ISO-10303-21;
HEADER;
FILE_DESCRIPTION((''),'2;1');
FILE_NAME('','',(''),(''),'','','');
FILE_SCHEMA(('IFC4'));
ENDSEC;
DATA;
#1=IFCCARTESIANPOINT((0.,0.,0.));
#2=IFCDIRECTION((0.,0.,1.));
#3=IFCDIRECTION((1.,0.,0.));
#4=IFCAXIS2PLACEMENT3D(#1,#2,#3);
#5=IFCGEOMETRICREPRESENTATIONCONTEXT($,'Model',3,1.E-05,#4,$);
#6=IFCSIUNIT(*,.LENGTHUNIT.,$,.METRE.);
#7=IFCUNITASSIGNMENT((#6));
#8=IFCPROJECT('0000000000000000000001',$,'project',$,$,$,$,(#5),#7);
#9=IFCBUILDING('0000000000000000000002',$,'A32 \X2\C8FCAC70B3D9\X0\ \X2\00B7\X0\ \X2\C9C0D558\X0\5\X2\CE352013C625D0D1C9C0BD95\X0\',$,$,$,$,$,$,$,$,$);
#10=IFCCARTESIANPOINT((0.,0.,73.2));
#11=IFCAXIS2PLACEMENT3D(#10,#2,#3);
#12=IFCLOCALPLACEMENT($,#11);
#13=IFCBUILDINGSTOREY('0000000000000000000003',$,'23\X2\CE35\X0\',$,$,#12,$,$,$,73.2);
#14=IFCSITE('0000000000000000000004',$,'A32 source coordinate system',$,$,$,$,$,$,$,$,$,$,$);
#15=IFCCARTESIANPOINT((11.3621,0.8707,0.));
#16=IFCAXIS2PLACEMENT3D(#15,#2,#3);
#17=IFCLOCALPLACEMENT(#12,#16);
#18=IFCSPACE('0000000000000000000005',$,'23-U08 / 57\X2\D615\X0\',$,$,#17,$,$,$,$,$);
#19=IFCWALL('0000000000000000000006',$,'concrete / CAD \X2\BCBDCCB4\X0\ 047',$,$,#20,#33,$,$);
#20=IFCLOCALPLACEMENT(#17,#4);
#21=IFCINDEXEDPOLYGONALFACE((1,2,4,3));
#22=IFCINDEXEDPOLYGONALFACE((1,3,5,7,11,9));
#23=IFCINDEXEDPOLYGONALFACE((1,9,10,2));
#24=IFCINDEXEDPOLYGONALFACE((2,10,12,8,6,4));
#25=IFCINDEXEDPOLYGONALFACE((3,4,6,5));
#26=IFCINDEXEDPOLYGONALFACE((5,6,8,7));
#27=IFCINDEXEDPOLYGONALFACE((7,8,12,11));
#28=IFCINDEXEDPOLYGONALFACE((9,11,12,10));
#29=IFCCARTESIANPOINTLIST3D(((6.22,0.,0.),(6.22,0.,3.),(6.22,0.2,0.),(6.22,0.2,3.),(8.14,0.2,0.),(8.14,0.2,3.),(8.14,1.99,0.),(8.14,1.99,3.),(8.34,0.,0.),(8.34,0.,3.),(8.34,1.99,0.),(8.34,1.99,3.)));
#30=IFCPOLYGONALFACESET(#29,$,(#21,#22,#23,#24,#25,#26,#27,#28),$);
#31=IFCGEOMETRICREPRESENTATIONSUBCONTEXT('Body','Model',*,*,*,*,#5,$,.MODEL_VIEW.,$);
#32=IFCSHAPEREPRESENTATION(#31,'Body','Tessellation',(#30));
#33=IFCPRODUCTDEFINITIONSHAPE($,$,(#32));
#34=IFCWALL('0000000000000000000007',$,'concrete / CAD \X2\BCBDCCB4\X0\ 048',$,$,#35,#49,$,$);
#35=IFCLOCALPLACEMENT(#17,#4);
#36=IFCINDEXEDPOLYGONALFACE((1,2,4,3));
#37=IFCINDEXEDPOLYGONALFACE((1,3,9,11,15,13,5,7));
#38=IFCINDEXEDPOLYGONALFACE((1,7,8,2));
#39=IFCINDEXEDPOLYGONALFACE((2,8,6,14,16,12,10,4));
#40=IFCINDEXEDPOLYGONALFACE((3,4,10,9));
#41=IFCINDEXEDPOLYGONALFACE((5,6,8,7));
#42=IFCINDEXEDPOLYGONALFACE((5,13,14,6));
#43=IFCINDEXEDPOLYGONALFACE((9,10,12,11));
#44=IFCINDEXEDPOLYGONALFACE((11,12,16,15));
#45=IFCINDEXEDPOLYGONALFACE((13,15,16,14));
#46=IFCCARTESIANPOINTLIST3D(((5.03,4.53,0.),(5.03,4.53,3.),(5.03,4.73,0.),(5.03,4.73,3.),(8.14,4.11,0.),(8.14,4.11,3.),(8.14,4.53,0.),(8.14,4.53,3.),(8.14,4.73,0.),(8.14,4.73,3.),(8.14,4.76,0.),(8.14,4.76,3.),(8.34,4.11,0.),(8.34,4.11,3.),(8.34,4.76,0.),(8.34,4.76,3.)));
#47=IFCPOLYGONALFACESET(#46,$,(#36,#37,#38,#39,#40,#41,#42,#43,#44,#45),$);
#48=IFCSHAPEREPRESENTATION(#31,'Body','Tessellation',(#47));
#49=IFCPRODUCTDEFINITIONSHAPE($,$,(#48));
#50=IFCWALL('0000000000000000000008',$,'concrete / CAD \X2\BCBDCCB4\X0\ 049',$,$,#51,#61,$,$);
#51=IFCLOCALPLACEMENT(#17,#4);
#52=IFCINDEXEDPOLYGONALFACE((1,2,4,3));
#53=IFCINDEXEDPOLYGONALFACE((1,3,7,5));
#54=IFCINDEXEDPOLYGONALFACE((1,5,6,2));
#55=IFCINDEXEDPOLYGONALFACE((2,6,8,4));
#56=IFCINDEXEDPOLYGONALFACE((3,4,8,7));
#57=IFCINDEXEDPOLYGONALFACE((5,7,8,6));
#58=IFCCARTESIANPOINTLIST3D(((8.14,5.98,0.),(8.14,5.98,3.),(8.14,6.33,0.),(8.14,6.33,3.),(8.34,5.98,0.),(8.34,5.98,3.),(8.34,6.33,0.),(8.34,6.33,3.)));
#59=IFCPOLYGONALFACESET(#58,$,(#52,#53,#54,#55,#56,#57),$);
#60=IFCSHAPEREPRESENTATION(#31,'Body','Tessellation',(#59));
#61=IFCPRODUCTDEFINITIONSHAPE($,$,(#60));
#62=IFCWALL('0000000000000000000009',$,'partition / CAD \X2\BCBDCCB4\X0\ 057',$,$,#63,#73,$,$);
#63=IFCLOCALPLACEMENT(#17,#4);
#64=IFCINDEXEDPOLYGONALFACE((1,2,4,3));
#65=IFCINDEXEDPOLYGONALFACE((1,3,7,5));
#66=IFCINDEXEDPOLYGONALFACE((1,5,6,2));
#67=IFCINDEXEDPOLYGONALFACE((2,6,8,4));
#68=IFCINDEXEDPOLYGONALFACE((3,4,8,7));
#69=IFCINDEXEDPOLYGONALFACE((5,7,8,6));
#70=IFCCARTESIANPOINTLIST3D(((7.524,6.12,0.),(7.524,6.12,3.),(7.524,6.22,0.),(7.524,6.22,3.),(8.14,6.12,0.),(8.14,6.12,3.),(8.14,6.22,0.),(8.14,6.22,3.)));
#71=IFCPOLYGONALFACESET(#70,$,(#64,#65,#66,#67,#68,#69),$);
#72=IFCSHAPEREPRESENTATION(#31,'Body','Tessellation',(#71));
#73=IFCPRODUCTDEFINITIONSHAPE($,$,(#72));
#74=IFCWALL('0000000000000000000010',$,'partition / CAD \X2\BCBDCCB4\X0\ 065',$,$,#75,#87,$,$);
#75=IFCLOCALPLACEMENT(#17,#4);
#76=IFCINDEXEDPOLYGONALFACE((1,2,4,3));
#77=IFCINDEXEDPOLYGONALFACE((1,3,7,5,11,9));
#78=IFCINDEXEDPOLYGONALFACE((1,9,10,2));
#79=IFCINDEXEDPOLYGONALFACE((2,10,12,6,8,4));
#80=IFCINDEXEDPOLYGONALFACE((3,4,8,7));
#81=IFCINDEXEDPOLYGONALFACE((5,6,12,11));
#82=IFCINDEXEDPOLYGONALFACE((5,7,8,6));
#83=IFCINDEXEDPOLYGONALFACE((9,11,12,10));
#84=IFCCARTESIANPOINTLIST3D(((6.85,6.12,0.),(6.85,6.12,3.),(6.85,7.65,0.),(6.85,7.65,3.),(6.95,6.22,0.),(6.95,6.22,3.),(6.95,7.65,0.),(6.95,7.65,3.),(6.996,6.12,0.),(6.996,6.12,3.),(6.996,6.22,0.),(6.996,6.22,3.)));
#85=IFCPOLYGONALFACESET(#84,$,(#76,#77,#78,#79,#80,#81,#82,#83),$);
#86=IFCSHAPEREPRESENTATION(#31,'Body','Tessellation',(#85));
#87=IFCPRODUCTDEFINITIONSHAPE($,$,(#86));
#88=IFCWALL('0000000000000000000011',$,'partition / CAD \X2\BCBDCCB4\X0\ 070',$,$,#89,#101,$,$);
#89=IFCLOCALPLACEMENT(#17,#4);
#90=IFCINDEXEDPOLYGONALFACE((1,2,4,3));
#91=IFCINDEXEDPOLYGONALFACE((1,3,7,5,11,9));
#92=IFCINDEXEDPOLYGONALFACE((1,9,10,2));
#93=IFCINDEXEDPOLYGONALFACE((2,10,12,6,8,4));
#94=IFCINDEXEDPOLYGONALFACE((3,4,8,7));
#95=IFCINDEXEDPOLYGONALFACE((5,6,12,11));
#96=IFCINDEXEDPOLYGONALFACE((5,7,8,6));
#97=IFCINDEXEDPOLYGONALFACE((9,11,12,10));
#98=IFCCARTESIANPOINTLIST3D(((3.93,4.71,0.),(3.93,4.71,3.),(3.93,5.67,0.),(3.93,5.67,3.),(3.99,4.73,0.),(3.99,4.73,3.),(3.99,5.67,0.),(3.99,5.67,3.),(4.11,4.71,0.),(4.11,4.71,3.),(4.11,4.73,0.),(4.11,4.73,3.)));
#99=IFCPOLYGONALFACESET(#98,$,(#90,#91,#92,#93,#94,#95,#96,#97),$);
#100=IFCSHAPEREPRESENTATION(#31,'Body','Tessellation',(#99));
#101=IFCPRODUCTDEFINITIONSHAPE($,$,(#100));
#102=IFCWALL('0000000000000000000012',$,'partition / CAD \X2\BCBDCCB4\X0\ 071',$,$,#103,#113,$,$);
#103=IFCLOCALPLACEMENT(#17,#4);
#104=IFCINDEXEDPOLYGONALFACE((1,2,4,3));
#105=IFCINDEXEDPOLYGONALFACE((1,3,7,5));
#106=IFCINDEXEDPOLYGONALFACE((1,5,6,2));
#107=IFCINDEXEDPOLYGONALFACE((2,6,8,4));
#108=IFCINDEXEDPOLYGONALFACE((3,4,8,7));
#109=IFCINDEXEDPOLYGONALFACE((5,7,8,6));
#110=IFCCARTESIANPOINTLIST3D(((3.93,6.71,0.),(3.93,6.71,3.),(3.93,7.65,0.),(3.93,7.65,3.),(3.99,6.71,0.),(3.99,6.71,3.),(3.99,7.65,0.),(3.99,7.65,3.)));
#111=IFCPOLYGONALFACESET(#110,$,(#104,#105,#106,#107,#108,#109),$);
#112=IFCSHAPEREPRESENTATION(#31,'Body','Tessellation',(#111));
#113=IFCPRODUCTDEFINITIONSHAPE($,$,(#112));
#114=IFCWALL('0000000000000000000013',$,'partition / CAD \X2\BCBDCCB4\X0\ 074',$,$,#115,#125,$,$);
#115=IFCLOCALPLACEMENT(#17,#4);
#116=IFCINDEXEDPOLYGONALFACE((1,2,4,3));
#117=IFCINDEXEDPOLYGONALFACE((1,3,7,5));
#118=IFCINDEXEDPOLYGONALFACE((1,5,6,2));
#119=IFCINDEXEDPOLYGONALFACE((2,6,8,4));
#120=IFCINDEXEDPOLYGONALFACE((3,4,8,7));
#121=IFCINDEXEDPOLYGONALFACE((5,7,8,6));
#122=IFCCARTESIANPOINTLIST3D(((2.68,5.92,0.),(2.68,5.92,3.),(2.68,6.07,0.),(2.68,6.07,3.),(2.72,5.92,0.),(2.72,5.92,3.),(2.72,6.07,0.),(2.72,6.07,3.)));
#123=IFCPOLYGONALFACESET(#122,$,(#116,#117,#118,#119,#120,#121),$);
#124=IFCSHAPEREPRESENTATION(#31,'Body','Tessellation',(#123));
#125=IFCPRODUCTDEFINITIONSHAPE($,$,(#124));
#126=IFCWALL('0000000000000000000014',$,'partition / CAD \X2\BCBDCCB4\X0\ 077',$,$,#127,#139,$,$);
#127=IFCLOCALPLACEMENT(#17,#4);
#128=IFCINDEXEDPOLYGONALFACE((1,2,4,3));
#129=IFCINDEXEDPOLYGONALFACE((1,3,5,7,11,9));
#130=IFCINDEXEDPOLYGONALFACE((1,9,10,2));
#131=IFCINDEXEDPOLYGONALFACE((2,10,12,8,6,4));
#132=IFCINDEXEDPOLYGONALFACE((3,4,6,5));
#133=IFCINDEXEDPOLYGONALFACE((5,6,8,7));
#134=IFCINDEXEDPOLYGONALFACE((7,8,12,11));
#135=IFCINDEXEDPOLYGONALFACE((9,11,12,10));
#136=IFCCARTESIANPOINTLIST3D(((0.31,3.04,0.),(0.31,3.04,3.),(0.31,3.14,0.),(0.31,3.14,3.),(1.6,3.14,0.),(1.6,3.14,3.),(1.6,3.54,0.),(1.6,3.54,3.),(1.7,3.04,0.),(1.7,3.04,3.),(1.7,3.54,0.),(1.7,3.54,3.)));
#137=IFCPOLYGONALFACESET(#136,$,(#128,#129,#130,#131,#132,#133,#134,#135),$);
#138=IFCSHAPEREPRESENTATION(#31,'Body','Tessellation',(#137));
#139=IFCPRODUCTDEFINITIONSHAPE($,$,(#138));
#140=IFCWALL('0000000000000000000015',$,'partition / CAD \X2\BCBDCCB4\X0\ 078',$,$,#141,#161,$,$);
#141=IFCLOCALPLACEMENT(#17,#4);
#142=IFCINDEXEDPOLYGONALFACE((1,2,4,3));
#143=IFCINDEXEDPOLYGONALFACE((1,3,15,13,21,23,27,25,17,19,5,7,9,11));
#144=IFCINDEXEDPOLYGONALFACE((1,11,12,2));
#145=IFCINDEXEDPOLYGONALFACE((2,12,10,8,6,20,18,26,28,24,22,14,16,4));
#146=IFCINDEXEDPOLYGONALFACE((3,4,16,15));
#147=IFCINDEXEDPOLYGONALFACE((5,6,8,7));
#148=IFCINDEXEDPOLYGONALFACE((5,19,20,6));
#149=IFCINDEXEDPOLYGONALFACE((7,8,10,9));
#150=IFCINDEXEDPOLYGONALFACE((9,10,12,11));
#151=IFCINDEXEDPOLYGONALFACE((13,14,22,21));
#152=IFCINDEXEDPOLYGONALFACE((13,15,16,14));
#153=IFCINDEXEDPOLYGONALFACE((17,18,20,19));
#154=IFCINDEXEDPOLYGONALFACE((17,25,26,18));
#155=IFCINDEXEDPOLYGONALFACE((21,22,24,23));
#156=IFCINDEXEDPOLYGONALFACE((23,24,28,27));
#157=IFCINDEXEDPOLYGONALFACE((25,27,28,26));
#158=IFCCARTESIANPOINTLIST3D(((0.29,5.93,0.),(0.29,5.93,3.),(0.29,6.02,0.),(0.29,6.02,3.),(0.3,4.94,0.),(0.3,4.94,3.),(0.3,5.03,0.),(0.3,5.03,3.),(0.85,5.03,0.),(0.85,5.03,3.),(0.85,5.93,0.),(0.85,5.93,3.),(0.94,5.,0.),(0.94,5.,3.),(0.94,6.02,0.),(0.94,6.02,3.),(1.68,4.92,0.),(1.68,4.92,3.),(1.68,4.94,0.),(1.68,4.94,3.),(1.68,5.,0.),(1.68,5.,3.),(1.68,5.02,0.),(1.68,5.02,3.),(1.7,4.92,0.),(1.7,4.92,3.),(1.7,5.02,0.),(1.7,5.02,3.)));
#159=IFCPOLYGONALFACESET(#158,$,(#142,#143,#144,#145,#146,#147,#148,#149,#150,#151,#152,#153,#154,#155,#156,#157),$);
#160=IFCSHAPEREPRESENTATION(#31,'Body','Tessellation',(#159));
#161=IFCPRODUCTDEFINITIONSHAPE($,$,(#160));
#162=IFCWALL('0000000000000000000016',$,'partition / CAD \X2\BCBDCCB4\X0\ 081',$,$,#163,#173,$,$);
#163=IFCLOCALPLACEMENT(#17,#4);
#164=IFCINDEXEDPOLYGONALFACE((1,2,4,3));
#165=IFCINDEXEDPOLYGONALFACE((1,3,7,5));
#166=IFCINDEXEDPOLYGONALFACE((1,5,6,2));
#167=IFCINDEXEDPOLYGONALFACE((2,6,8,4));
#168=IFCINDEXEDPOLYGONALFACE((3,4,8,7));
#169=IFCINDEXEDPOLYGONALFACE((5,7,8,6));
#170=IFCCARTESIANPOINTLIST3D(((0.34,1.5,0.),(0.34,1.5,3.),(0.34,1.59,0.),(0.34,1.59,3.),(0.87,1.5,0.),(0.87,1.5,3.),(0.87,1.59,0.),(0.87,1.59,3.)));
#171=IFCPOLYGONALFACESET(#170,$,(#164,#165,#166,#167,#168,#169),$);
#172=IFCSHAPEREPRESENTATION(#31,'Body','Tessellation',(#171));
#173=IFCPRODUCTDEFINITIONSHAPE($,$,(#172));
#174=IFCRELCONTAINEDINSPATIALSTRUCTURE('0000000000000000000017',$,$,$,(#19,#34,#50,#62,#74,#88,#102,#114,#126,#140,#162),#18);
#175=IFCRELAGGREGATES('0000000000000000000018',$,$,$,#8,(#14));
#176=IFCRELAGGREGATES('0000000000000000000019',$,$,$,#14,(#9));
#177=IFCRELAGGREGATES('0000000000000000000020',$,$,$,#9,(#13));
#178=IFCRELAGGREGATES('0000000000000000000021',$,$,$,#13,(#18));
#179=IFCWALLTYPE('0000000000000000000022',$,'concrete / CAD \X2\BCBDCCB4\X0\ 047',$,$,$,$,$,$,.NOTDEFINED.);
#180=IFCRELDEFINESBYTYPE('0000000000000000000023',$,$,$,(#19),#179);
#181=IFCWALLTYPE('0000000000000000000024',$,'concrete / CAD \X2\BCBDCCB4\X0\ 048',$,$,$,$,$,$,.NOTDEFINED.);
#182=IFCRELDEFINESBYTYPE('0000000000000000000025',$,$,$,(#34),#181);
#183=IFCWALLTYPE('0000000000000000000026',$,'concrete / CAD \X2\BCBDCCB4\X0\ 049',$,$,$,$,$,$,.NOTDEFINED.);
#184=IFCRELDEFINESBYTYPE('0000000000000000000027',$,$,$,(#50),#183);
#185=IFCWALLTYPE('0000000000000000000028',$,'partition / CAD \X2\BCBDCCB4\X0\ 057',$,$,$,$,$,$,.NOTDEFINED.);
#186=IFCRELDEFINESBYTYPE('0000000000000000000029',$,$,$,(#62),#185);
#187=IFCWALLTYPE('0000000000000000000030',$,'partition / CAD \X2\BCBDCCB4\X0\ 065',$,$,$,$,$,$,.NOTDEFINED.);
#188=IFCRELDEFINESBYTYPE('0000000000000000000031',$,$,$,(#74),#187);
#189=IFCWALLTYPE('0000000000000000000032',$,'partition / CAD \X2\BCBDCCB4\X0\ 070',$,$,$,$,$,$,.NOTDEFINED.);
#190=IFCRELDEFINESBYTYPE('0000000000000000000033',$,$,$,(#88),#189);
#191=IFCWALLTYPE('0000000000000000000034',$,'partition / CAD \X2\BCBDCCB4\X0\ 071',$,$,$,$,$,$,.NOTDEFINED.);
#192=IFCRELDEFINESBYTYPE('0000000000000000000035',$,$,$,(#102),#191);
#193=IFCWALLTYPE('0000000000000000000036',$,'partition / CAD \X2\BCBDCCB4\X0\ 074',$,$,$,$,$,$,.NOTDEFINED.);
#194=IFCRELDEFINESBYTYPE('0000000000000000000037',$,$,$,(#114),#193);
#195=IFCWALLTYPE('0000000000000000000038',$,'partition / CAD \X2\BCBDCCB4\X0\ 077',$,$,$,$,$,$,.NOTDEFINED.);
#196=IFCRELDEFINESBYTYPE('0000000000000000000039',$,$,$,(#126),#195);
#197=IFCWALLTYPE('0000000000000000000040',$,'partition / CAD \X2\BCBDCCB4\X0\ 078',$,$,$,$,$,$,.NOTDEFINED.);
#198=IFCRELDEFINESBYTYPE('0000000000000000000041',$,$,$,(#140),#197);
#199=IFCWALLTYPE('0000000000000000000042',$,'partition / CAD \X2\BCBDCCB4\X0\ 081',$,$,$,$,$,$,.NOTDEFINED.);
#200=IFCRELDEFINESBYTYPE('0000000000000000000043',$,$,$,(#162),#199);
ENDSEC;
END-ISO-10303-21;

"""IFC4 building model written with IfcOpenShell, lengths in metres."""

from ifc_helpers import new_model, si_unit, frame, origin, origin_with_axes, place, context, subcontext, project, spatial, polyline, outline, extrude, source, transform, mapped, type_object, type_shapes, element, save


model = new_model("IFC4")

# Units and contexts
model_context = context("Model", 3, precision=1e-05, world=origin_with_axes())
body_context = subcontext(model_context, "Body", "Model", "MODEL_VIEW")
ifc_project = project(units=[si_unit("LENGTHUNIT", "METRE")], contexts=[model_context])

# Site, building, storey, space
site = spatial("IfcSite", under=ifc_project, Name="A32 source coordinate system")
building = spatial("IfcBuilding", under=site, Name="A32 주거동 · 지하5층–옥탑지붕")
storey_placement = place(None, frame((0.0, 0.0, 73.2), z_axis=(0.0, 0.0, 1.0), x_axis=(1.0, 0.0, 0.0)))
storey = spatial("IfcBuildingStorey", under=building, at=storey_placement, Name="23층", Elevation=73.2)
space_placement = place(storey_placement, frame((11.3621, 0.8707, 0.0), z_axis=(0.0, 0.0, 1.0), x_axis=(1.0, 0.0, 0.0)))
space = spatial("IfcSpace", under=storey, at=space_placement, Name="23-U08 / 57형")

# Walls
wall_type_1 = type_object("IfcWallType", Name="concrete / CAD 벽체 047", PredefinedType="NOTDEFINED")
shared_shape_1 = source(origin(), body_context, "Body", "SweptSolid", [
    extrude(outline(polyline([(8.14, 1.99), (8.34, 1.99), (8.34, 0.0), (6.22, 0.0), (6.22, 0.2), (8.14, 0.2), (8.14, 1.99)])), origin(), (0.0, 0.0, 1.0), 3.0),
])
type_shapes(wall_type_1, [shared_shape_1])
wall_1_placement = place(space_placement, origin_with_axes())
element("IfcWall", 1, at=wall_1_placement, inside=space, type_object=wall_type_1, Name="concrete / CAD 벽체 047", context=body_context, shape_type="MappedRepresentation", body=[
    mapped(shared_shape_1, transform((0.0, 0.0, 0.0), scale=1.0)),
])
wall_type_2 = type_object("IfcWallType", Name="concrete / CAD 벽체 048", PredefinedType="NOTDEFINED")
shared_shape_2 = source(origin(), body_context, "Body", "SweptSolid", [
    extrude(outline(polyline([(8.14, 4.53), (5.03, 4.53), (5.03, 4.73), (8.14, 4.73), (8.14, 4.76), (8.34, 4.76), (8.34, 4.11), (8.14, 4.11), (8.14, 4.53)])), origin(), (0.0, 0.0, 1.0), 3.0),
])
type_shapes(wall_type_2, [shared_shape_2])
wall_2_placement = place(space_placement, origin_with_axes())
element("IfcWall", 2, at=wall_2_placement, inside=space, type_object=wall_type_2, Name="concrete / CAD 벽체 048", context=body_context, shape_type="MappedRepresentation", body=[
    mapped(shared_shape_2, transform((0.0, 0.0, 0.0), scale=1.0)),
])
wall_type_3 = type_object("IfcWallType", Name="concrete / CAD 벽체 049", PredefinedType="NOTDEFINED")
shared_shape_3 = source(origin(), body_context, "Body", "SweptSolid", [
    extrude(outline(polyline([(8.34, 6.33), (8.34, 5.98), (8.14, 5.98), (8.14, 6.33), (8.34, 6.33)])), origin(), (0.0, 0.0, 1.0), 3.0),
])
type_shapes(wall_type_3, [shared_shape_3])
wall_3_placement = place(space_placement, origin_with_axes())
element("IfcWall", 3, at=wall_3_placement, inside=space, type_object=wall_type_3, Name="concrete / CAD 벽체 049", context=body_context, shape_type="MappedRepresentation", body=[
    mapped(shared_shape_3, transform((0.0, 0.0, 0.0), scale=1.0)),
])
wall_type_4 = type_object("IfcWallType", Name="partition / CAD 벽체 057", PredefinedType="NOTDEFINED")
shared_shape_4 = source(origin(), body_context, "Body", "SweptSolid", [
    extrude(outline(polyline([(7.524, 6.22), (8.14, 6.22), (8.14, 6.12), (7.524, 6.12), (7.524, 6.22)])), origin(), (0.0, 0.0, 1.0), 3.0),
])
type_shapes(wall_type_4, [shared_shape_4])
wall_4_placement = place(space_placement, origin_with_axes())
element("IfcWall", 4, at=wall_4_placement, inside=space, type_object=wall_type_4, Name="partition / CAD 벽체 057", context=body_context, shape_type="MappedRepresentation", body=[
    mapped(shared_shape_4, transform((0.0, 0.0, 0.0), scale=1.0)),
])
wall_type_5 = type_object("IfcWallType", Name="partition / CAD 벽체 065", PredefinedType="NOTDEFINED")
shared_shape_5 = source(origin(), body_context, "Body", "SweptSolid", [
    extrude(outline(polyline([(6.95, 7.65), (6.95, 6.22), (6.996, 6.22), (6.996, 6.12), (6.85, 6.12), (6.85, 7.65), (6.95, 7.65)])), origin(), (0.0, 0.0, 1.0), 3.0),
])
type_shapes(wall_type_5, [shared_shape_5])
wall_5_placement = place(space_placement, origin_with_axes())
element("IfcWall", 5, at=wall_5_placement, inside=space, type_object=wall_type_5, Name="partition / CAD 벽체 065", context=body_context, shape_type="MappedRepresentation", body=[
    mapped(shared_shape_5, transform((0.0, 0.0, 0.0), scale=1.0)),
])
wall_type_6 = type_object("IfcWallType", Name="partition / CAD 벽체 070", PredefinedType="NOTDEFINED")
shared_shape_6 = source(origin(), body_context, "Body", "SweptSolid", [
    extrude(outline(polyline([(4.11, 4.73), (4.11, 4.71), (3.93, 4.71), (3.93, 5.67), (3.99, 5.67), (3.99, 4.73), (4.11, 4.73)])), origin(), (0.0, 0.0, 1.0), 3.0),
])
type_shapes(wall_type_6, [shared_shape_6])
wall_6_placement = place(space_placement, origin_with_axes())
element("IfcWall", 6, at=wall_6_placement, inside=space, type_object=wall_type_6, Name="partition / CAD 벽체 070", context=body_context, shape_type="MappedRepresentation", body=[
    mapped(shared_shape_6, transform((0.0, 0.0, 0.0), scale=1.0)),
])
wall_type_7 = type_object("IfcWallType", Name="partition / CAD 벽체 071", PredefinedType="NOTDEFINED")
shared_shape_7 = source(origin(), body_context, "Body", "SweptSolid", [
    extrude(outline(polyline([(3.93, 6.71), (3.93, 7.65), (3.99, 7.65), (3.99, 6.71), (3.93, 6.71)])), origin(), (0.0, 0.0, 1.0), 3.0),
])
type_shapes(wall_type_7, [shared_shape_7])
wall_7_placement = place(space_placement, origin_with_axes())
element("IfcWall", 7, at=wall_7_placement, inside=space, type_object=wall_type_7, Name="partition / CAD 벽체 071", context=body_context, shape_type="MappedRepresentation", body=[
    mapped(shared_shape_7, transform((0.0, 0.0, 0.0), scale=1.0)),
])
wall_type_8 = type_object("IfcWallType", Name="partition / CAD 벽체 074", PredefinedType="NOTDEFINED")
shared_shape_8 = source(origin(), body_context, "Body", "SweptSolid", [
    extrude(outline(polyline([(2.72, 6.07), (2.72, 5.92), (2.68, 5.92), (2.68, 6.07), (2.72, 6.07)])), origin(), (0.0, 0.0, 1.0), 3.0),
])
type_shapes(wall_type_8, [shared_shape_8])
wall_8_placement = place(space_placement, origin_with_axes())
element("IfcWall", 8, at=wall_8_placement, inside=space, type_object=wall_type_8, Name="partition / CAD 벽체 074", context=body_context, shape_type="MappedRepresentation", body=[
    mapped(shared_shape_8, transform((0.0, 0.0, 0.0), scale=1.0)),
])
wall_type_9 = type_object("IfcWallType", Name="partition / CAD 벽체 077", PredefinedType="NOTDEFINED")
shared_shape_9 = source(origin(), body_context, "Body", "SweptSolid", [
    extrude(outline(polyline([(1.7, 3.54), (1.7, 3.04), (0.31, 3.04), (0.31, 3.14), (1.6, 3.14), (1.6, 3.54), (1.7, 3.54)])), origin(), (0.0, 0.0, 1.0), 3.0),
])
type_shapes(wall_type_9, [shared_shape_9])
wall_9_placement = place(space_placement, origin_with_axes())
element("IfcWall", 9, at=wall_9_placement, inside=space, type_object=wall_type_9, Name="partition / CAD 벽체 077", context=body_context, shape_type="MappedRepresentation", body=[
    mapped(shared_shape_9, transform((0.0, 0.0, 0.0), scale=1.0)),
])
wall_type_10 = type_object("IfcWallType", Name="partition / CAD 벽체 078", PredefinedType="NOTDEFINED")
shared_shape_10 = source(origin(), body_context, "Body", "SweptSolid", [
    extrude(outline(polyline([(1.7, 4.92), (1.68, 4.92), (1.68, 4.94), (0.3, 4.94), (0.3, 5.03), (0.85, 5.03), (0.85, 5.93), (0.29, 5.93), (0.29, 6.02), (0.94, 6.02), (0.94, 5.0), (1.68, 5.0), (1.68, 5.02), (1.7, 5.02), (1.7, 4.92)])), origin(), (0.0, 0.0, 1.0), 3.0),
])
type_shapes(wall_type_10, [shared_shape_10])
wall_10_placement = place(space_placement, origin_with_axes())
element("IfcWall", 10, at=wall_10_placement, inside=space, type_object=wall_type_10, Name="partition / CAD 벽체 078", context=body_context, shape_type="MappedRepresentation", body=[
    mapped(shared_shape_10, transform((0.0, 0.0, 0.0), scale=1.0)),
])
wall_type_11 = type_object("IfcWallType", Name="partition / CAD 벽체 081", PredefinedType="NOTDEFINED")
shared_shape_11 = source(origin(), body_context, "Body", "SweptSolid", [
    extrude(outline(polyline([(0.34, 1.59), (0.87, 1.59), (0.87, 1.5), (0.34, 1.5), (0.34, 1.59)])), origin(), (0.0, 0.0, 1.0), 3.0),
])
type_shapes(wall_type_11, [shared_shape_11])
wall_11_placement = place(space_placement, origin_with_axes())
element("IfcWall", 11, at=wall_11_placement, inside=space, type_object=wall_type_11, Name="partition / CAD 벽체 081", context=body_context, shape_type="MappedRepresentation", body=[
    mapped(shared_shape_11, transform((0.0, 0.0, 0.0), scale=1.0)),
])

save(model, "model.ifc")
